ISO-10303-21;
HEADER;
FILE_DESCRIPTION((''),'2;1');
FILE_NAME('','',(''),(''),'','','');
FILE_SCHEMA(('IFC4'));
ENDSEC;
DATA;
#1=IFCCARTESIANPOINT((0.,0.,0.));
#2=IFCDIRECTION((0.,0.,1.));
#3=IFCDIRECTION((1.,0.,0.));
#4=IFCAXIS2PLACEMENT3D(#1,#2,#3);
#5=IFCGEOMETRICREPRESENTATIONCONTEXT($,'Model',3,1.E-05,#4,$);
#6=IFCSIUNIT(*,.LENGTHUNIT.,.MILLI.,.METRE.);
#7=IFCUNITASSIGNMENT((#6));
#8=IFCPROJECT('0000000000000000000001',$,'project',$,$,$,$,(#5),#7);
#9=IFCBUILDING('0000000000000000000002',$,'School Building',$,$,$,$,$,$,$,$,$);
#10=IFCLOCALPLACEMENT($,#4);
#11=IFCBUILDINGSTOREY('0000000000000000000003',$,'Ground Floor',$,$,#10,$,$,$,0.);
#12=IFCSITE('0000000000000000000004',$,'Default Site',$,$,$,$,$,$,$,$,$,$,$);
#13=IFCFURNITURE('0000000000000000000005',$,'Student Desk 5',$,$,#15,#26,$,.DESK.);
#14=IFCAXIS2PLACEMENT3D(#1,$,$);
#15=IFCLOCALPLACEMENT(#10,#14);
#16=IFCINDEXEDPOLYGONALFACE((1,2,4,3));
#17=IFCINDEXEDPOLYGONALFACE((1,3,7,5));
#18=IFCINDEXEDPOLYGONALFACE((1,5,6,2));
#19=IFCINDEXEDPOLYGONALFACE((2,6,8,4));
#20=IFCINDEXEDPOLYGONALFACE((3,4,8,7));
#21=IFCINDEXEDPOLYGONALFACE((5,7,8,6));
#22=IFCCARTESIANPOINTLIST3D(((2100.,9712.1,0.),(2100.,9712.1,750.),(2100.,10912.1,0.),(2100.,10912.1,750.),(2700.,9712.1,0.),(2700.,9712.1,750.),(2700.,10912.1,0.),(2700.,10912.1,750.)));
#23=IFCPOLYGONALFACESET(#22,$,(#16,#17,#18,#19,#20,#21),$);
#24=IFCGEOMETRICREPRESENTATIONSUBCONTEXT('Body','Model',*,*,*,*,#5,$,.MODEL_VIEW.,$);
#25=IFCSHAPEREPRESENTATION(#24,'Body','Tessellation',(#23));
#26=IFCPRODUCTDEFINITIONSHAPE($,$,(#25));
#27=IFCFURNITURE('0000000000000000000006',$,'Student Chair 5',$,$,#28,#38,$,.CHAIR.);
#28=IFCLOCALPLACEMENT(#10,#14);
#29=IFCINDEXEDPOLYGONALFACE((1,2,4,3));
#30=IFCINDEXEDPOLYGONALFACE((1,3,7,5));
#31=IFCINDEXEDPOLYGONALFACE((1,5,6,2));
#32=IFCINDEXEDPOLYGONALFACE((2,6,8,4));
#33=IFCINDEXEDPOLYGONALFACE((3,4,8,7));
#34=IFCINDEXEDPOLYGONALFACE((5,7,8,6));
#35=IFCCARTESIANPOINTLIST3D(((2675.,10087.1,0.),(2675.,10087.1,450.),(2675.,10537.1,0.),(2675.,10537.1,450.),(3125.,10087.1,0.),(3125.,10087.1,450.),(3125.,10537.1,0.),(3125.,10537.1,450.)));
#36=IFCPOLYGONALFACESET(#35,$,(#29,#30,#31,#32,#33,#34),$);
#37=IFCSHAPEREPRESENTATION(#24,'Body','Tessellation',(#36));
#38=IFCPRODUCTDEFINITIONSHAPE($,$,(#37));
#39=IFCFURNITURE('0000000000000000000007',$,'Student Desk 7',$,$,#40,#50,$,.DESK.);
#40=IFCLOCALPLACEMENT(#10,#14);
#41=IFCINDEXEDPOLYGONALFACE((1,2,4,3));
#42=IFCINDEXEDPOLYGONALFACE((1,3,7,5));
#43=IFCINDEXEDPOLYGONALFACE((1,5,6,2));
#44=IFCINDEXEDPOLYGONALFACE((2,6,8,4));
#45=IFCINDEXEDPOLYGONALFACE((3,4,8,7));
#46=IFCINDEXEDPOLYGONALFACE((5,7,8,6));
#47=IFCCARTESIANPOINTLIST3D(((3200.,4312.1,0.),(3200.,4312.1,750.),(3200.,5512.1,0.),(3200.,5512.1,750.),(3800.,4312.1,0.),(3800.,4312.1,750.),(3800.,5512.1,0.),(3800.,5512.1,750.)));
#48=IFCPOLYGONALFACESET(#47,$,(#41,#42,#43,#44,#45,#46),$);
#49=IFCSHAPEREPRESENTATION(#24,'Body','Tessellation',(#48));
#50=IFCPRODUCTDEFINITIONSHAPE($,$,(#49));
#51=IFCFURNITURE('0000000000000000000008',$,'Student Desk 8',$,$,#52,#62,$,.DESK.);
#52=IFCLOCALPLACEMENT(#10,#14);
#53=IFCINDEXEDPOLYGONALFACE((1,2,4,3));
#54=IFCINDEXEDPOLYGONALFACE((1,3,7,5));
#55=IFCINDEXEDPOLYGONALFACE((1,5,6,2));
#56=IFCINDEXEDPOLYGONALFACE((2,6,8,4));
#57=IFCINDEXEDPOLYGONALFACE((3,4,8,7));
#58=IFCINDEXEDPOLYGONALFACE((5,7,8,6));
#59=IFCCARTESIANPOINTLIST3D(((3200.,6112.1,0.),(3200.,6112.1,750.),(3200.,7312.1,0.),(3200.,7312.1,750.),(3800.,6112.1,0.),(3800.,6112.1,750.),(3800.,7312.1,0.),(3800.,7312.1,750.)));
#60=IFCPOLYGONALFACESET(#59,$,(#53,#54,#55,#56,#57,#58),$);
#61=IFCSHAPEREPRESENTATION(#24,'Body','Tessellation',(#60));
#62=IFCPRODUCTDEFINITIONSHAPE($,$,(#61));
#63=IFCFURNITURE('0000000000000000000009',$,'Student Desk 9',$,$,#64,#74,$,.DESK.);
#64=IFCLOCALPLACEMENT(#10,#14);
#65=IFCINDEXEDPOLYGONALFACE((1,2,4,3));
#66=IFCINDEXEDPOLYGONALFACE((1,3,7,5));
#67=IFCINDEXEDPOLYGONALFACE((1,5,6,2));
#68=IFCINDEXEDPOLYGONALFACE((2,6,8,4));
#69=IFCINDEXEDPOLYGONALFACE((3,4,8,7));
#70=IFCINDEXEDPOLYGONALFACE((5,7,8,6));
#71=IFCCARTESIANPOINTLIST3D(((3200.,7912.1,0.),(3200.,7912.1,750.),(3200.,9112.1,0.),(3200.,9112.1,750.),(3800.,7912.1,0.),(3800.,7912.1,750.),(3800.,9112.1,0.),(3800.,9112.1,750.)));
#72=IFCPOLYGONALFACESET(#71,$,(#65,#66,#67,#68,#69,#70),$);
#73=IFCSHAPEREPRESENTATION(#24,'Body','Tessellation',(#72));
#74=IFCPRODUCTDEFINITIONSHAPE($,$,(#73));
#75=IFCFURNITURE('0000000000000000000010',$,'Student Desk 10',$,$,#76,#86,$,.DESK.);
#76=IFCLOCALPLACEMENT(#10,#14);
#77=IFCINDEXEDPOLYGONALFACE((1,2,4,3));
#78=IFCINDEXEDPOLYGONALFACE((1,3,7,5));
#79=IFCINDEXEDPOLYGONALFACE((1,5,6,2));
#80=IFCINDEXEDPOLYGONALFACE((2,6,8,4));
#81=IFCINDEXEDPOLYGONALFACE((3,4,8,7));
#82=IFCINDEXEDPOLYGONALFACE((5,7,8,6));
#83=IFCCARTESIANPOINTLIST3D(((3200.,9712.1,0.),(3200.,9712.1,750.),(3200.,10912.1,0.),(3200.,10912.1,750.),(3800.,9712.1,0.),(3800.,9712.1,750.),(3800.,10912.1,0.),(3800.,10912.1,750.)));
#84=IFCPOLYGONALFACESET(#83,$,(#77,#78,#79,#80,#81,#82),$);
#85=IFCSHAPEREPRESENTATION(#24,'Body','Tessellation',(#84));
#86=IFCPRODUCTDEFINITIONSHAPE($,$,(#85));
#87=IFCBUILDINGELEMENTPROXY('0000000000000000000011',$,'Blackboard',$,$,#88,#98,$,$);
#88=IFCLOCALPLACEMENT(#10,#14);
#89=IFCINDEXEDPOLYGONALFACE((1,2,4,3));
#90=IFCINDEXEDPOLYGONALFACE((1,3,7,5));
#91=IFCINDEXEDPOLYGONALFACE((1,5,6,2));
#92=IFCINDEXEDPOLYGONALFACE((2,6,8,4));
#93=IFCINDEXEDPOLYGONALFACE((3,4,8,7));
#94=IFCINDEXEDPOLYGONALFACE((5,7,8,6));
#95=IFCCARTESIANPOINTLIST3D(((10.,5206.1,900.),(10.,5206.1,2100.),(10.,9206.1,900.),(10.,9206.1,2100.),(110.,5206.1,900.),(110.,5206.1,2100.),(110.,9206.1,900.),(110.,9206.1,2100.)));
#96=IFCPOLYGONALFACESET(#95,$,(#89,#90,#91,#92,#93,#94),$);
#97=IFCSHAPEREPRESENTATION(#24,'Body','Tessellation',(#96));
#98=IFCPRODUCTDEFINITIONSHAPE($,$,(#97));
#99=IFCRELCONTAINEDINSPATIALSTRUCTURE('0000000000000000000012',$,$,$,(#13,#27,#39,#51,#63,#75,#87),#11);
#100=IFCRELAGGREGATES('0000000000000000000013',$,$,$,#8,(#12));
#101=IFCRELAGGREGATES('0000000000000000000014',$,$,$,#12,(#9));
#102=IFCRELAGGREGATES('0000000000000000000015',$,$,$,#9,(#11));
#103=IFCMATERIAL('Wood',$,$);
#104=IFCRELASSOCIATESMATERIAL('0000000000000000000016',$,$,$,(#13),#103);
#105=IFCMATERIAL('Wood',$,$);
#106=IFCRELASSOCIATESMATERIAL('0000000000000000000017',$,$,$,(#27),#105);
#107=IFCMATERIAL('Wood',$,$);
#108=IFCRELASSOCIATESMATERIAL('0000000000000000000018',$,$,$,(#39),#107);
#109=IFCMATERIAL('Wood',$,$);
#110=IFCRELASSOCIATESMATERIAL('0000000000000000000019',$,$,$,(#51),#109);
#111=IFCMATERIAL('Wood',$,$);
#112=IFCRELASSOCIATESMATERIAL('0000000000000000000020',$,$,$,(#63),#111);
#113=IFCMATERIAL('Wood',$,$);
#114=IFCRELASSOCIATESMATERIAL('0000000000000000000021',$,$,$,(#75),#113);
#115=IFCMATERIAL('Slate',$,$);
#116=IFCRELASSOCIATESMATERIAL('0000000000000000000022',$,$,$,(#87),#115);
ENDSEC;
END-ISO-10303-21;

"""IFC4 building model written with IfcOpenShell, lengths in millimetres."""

from ifc_helpers import new_model, si_unit, frame, origin_with_axes, origin_2d, place, context, subcontext, project, spatial, rectangle, extrude, material, element, save


model = new_model("IFC4")

# Units and contexts
model_context = context("Model", 3, precision=1e-05, world=origin_with_axes())
body_context = subcontext(model_context, "Body", "Model", "MODEL_VIEW")
ifc_project = project(units=[si_unit("LENGTHUNIT", "METRE", prefix="MILLI")], contexts=[model_context])

# Site, building, storey
site = spatial("IfcSite", under=ifc_project, Name="Default Site")
building = spatial("IfcBuilding", under=site, Name="School Building")
storey_placement = place(None, origin_with_axes())
storey = spatial("IfcBuildingStorey", under=building, at=storey_placement, Name="Ground Floor", Elevation=0.0)

# Furniture
ifc_material_1 = material(Name="Wood")
furniture_1_placement = place(storey_placement, frame((2400.0, 10312.1, 0.0), z_axis=(0.0, 0.0, 1.0), x_axis=(0.0, 1.0, 0.0)))
element("IfcFurniture", 1, at=furniture_1_placement, inside=storey, material=ifc_material_1, Name="Student Desk 5", PredefinedType="DESK", context=body_context, shape_type="SweptSolid", body=[
    extrude(rectangle(XDim=1200.0, YDim=600.0, at=origin_2d()), origin_with_axes(), (0.0, 0.0, 1.0), 750.0),
])
ifc_material_2 = material(Name="Wood")
furniture_2_placement = place(storey_placement, frame((2900.0, 10312.1, 0.0), z_axis=(0.0, 0.0, 1.0), x_axis=(1.0, 0.0, 0.0)))
element("IfcFurniture", 2, at=furniture_2_placement, inside=storey, material=ifc_material_2, Name="Student Chair 5", PredefinedType="CHAIR", context=body_context, shape_type="SweptSolid", body=[
    extrude(rectangle(XDim=450.0, YDim=450.0, at=origin_2d()), origin_with_axes(), (0.0, 0.0, 1.0), 450.0),
])
ifc_material_3 = material(Name="Wood")
furniture_3_placement = place(storey_placement, frame((3500.0, 4912.1, 0.0), z_axis=(0.0, 0.0, 1.0), x_axis=(0.0, 1.0, 0.0)))
element("IfcFurniture", 3, at=furniture_3_placement, inside=storey, material=ifc_material_3, Name="Student Desk 7", PredefinedType="DESK", context=body_context, shape_type="SweptSolid", body=[
    extrude(rectangle(XDim=1200.0, YDim=600.0, at=origin_2d()), origin_with_axes(), (0.0, 0.0, 1.0), 750.0),
])
ifc_material_4 = material(Name="Wood")
furniture_4_placement = place(storey_placement, frame((3500.0, 6712.1, 0.0), z_axis=(0.0, 0.0, 1.0), x_axis=(0.0, 1.0, 0.0)))
element("IfcFurniture", 4, at=furniture_4_placement, inside=storey, material=ifc_material_4, Name="Student Desk 8", PredefinedType="DESK", context=body_context, shape_type="SweptSolid", body=[
    extrude(rectangle(XDim=1200.0, YDim=600.0, at=origin_2d()), origin_with_axes(), (0.0, 0.0, 1.0), 750.0),
])
ifc_material_5 = material(Name="Wood")
furniture_5_placement = place(storey_placement, frame((3500.0, 8512.1, 0.0), z_axis=(0.0, 0.0, 1.0), x_axis=(0.0, 1.0, 0.0)))
element("IfcFurniture", 5, at=furniture_5_placement, inside=storey, material=ifc_material_5, Name="Student Desk 9", PredefinedType="DESK", context=body_context, shape_type="SweptSolid", body=[
    extrude(rectangle(XDim=1200.0, YDim=600.0, at=origin_2d()), origin_with_axes(), (0.0, 0.0, 1.0), 750.0),
])
ifc_material_6 = material(Name="Wood")
furniture_6_placement = place(storey_placement, frame((3500.0, 10312.1, 0.0), z_axis=(0.0, 0.0, 1.0), x_axis=(0.0, 1.0, 0.0)))
element("IfcFurniture", 6, at=furniture_6_placement, inside=storey, material=ifc_material_6, Name="Student Desk 10", PredefinedType="DESK", context=body_context, shape_type="SweptSolid", body=[
    extrude(rectangle(XDim=1200.0, YDim=600.0, at=origin_2d()), origin_with_axes(), (0.0, 0.0, 1.0), 750.0),
])

# Building element proxy
ifc_material_7 = material(Name="Slate")
proxy_placement = place(storey_placement, frame((60.0, 7206.1, 900.0), z_axis=(0.0, 0.0, 1.0), x_axis=(1.0, 0.0, 0.0)))
element("IfcBuildingElementProxy", 7, at=proxy_placement, inside=storey, material=ifc_material_7, Name="Blackboard", context=body_context, shape_type="SweptSolid", body=[
    extrude(rectangle(XDim=100.0, YDim=4000.0, at=origin_2d()), origin_with_axes(), (0.0, 0.0, 1.0), 1200.0),
])

save(model, "model.ifc")
